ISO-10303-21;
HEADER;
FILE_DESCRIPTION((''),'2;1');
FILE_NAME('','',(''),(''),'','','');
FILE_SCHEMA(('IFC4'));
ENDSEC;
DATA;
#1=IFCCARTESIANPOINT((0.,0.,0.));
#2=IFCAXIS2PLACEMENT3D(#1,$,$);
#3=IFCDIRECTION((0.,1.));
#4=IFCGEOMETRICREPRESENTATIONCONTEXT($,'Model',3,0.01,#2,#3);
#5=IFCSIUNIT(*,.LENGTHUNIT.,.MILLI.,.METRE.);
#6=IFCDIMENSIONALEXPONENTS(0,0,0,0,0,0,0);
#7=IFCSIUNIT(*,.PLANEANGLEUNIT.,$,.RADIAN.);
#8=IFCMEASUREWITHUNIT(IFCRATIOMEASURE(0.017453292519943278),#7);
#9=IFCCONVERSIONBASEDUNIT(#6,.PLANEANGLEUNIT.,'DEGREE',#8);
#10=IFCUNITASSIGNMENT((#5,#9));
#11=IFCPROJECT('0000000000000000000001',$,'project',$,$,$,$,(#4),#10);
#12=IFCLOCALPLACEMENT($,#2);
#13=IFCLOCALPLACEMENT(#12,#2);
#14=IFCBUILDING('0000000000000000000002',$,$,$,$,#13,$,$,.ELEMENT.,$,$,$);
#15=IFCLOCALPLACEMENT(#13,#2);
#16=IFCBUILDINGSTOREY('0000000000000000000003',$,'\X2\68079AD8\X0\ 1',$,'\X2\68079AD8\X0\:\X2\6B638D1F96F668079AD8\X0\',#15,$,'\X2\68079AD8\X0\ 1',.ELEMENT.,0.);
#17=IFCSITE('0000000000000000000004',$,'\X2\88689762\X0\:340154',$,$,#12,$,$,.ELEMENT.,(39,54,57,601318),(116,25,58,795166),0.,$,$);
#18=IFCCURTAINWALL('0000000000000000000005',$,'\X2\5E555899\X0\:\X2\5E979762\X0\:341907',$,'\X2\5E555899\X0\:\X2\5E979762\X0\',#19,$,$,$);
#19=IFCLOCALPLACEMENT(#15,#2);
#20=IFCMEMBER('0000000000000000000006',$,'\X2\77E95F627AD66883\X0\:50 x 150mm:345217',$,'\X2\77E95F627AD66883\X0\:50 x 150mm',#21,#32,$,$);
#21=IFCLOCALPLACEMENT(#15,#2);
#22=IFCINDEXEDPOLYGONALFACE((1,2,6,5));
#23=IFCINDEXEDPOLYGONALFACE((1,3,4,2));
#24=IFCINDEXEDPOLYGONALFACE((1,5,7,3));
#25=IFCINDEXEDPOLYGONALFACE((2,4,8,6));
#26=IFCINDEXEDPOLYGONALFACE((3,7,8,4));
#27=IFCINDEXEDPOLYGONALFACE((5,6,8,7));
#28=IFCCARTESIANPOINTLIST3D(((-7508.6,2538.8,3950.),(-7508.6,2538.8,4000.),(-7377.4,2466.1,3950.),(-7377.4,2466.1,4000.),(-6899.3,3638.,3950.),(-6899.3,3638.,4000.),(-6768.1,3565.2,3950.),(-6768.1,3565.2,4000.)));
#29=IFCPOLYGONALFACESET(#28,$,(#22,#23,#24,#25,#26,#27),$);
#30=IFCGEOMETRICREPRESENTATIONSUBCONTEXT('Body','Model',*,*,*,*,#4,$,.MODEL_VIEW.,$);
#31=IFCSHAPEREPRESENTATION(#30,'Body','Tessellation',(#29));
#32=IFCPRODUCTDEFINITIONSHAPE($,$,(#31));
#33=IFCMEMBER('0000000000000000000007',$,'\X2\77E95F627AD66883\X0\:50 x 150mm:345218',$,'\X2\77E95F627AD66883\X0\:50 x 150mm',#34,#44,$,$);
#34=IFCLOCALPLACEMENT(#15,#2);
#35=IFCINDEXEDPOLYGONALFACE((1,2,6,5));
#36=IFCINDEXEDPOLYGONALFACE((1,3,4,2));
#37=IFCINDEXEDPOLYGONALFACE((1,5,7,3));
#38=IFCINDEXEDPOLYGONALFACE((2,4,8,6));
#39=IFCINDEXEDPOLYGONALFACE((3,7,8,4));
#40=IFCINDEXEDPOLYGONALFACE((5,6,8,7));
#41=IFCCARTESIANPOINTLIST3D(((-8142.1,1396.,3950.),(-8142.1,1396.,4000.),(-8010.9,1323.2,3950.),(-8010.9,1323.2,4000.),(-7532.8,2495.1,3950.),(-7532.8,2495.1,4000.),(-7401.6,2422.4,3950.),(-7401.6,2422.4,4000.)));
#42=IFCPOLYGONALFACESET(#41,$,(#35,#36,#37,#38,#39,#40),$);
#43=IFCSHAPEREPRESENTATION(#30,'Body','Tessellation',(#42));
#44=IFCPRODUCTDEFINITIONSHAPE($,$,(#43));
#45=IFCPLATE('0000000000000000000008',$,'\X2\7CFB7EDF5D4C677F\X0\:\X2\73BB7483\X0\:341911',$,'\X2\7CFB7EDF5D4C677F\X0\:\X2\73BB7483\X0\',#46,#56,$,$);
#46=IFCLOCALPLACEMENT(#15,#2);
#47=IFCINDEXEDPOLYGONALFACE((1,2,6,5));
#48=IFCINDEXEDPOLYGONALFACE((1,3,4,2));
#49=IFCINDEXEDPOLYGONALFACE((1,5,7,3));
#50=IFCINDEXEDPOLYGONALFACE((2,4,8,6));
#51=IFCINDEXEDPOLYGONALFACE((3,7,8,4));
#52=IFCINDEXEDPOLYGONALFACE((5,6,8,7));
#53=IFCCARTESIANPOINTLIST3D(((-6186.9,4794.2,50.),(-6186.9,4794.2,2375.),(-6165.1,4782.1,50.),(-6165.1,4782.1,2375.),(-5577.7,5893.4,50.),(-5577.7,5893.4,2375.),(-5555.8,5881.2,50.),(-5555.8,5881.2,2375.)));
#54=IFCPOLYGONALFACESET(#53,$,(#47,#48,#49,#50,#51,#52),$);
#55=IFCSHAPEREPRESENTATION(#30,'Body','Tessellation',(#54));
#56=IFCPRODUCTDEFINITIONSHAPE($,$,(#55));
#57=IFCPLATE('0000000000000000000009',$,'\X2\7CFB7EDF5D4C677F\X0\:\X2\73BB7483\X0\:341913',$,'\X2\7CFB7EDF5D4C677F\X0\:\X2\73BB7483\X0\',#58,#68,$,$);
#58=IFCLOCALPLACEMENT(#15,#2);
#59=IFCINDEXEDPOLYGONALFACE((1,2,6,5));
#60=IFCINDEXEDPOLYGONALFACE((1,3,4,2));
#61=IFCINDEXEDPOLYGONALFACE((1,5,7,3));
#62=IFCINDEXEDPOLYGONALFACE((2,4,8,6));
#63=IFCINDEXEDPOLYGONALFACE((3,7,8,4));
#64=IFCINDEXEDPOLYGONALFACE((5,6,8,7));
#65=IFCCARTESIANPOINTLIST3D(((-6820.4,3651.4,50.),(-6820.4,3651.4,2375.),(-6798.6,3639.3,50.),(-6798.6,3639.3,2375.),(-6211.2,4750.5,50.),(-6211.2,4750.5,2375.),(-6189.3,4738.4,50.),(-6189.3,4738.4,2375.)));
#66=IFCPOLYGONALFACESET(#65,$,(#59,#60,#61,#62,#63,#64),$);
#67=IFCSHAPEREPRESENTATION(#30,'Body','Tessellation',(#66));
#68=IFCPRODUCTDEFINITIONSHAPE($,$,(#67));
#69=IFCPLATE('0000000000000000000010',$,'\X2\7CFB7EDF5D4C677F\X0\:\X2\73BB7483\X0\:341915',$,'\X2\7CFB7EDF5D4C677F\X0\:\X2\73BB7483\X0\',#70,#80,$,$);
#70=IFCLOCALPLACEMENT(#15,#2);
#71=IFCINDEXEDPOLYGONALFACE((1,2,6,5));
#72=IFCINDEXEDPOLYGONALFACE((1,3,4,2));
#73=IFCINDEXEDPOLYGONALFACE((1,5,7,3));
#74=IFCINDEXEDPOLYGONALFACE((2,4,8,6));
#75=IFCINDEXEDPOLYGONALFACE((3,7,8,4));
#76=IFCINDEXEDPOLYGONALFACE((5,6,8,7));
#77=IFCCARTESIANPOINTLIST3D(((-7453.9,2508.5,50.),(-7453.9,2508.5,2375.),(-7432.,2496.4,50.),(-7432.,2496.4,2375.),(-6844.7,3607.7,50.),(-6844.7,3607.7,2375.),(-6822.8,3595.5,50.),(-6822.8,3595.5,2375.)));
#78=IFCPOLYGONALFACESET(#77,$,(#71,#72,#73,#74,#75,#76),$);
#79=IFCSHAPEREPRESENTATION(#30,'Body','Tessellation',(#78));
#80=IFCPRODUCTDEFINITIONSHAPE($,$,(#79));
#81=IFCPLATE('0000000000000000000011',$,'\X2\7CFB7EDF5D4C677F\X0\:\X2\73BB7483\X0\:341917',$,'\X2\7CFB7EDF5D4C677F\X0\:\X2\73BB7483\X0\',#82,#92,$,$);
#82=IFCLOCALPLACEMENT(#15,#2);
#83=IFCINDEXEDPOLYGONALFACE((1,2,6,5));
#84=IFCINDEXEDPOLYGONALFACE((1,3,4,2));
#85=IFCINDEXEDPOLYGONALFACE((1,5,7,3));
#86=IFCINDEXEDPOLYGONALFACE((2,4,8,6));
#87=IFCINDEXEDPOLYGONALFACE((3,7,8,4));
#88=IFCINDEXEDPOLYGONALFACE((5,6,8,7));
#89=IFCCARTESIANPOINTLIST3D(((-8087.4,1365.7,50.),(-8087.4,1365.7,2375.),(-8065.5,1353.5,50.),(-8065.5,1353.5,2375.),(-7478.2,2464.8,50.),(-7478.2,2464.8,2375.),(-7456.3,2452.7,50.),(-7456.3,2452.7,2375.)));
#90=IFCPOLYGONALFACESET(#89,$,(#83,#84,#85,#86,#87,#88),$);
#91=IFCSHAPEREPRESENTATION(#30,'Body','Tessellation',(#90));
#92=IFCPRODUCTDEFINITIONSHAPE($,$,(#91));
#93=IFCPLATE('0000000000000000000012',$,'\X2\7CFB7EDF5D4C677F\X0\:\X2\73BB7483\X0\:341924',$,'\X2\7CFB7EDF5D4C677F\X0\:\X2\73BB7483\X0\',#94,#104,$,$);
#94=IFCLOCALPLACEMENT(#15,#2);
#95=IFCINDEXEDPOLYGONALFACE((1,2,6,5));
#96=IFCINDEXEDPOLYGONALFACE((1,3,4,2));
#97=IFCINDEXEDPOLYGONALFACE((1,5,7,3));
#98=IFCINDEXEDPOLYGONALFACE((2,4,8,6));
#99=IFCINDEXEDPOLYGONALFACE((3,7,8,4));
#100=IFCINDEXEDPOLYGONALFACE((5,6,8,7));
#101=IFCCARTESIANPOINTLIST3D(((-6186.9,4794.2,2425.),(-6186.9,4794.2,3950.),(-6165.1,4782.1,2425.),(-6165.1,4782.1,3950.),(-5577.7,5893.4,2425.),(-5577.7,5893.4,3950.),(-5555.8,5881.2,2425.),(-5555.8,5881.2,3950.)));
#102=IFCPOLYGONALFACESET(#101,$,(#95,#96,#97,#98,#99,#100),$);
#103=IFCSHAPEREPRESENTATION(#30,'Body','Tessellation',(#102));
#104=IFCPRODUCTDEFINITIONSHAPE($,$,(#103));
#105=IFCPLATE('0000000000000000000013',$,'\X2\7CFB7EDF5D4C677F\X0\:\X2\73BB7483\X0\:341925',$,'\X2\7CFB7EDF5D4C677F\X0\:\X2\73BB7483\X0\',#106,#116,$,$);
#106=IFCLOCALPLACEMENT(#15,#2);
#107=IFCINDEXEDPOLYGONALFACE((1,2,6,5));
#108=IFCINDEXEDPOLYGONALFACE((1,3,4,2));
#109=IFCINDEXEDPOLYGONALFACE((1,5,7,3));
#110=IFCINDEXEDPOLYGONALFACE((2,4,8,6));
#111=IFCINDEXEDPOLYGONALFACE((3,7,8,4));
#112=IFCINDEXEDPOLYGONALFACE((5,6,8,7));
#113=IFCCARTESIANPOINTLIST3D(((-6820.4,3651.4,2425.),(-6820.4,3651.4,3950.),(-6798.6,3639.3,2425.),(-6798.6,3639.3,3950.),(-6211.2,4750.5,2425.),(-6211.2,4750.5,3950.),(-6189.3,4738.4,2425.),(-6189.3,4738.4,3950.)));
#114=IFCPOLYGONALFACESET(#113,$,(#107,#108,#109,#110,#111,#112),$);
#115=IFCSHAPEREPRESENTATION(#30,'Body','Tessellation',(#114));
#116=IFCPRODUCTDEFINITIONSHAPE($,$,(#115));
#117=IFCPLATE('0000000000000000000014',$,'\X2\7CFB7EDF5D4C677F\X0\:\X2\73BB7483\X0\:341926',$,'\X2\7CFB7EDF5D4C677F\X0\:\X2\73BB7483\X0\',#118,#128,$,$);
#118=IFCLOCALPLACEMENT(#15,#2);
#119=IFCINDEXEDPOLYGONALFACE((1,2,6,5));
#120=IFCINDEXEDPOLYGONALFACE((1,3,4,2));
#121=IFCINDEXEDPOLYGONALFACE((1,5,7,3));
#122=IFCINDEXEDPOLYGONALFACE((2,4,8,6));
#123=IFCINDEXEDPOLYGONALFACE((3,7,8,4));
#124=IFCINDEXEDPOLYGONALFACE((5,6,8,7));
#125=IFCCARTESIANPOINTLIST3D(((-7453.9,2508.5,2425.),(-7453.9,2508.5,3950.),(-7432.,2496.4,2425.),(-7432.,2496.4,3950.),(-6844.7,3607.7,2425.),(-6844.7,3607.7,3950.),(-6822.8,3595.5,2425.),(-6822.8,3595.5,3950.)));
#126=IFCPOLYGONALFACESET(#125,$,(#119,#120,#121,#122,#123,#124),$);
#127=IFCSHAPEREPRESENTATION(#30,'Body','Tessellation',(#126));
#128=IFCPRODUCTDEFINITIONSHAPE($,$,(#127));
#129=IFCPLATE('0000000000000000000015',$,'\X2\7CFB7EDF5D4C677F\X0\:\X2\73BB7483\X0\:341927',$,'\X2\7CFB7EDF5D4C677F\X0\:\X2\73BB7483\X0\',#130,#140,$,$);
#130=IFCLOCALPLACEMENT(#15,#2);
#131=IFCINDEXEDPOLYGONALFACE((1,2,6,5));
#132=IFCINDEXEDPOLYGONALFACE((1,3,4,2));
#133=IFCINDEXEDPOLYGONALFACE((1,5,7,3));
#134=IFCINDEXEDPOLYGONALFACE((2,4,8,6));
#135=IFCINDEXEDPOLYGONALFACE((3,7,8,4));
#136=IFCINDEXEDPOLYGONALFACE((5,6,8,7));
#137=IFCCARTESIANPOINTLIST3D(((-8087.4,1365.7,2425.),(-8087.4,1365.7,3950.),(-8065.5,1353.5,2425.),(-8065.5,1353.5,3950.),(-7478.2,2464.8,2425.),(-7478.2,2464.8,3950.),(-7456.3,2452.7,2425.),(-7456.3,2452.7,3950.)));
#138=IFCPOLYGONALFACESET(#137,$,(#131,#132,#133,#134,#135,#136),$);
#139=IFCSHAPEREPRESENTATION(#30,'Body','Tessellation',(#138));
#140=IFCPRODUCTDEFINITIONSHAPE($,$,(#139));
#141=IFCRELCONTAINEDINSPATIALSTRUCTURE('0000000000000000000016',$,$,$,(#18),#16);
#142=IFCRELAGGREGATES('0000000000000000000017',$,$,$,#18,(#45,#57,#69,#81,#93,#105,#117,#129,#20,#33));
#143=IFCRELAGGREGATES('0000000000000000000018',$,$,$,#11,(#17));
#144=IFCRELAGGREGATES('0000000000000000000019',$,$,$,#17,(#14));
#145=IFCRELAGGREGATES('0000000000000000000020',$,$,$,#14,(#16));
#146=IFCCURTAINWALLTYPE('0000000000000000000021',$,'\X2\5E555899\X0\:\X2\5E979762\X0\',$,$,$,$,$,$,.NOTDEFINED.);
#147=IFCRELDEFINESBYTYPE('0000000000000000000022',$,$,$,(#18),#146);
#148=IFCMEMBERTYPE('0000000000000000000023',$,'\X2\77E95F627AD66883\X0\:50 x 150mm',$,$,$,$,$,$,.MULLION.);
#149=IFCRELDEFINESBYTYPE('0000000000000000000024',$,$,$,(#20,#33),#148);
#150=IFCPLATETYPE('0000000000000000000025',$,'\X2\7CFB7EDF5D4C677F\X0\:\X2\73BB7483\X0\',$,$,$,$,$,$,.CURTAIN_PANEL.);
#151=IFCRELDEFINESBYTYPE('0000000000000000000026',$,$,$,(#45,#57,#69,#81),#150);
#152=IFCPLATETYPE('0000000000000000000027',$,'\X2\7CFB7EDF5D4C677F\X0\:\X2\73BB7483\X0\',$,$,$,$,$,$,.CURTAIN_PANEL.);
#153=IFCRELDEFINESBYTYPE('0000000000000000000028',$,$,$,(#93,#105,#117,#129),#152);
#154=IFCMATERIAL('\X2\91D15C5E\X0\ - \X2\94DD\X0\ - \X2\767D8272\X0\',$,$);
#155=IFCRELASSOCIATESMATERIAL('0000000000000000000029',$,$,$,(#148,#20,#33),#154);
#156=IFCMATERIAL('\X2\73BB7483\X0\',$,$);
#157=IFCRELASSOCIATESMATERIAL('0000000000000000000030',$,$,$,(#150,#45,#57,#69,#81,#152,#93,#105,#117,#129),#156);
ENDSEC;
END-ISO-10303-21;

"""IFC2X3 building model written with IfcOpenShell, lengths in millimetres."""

from ifc_helpers import new_model, entity, si_unit, converted_unit, direction, frame, frame_2d, origin, origin_2d_with_axis, place, context, subcontext, project, spatial, rectangle, extrude, source, transform, mapped, material, type_object, type_shapes, element, aggregate, save


model = new_model("IFC2X3")

# Units and contexts
model_context = context("Model", 3, precision=0.01, world=origin(), true_north=direction((0.0, 1.0)))
body_context = subcontext(model_context, "Body", "Model", "MODEL_VIEW")
ifc_project = project(units=[si_unit("LENGTHUNIT", "METRE", prefix="MILLI"), converted_unit("PLANEANGLEUNIT", "DEGREE", entity("IfcRatioMeasure", 0.017453292519943278), si_unit("PLANEANGLEUNIT", "RADIAN"), dimensions=[0, 0, 0, 0, 0, 0, 0])], contexts=[model_context])

# Site, building, storey
site_placement = place(None, origin())
site = spatial("IfcSite", under=ifc_project, at=site_placement, Name="表面:340154", CompositionType="ELEMENT", RefLatitude=(39, 54, 57, 601318), RefLongitude=(116, 25, 58, 795166), RefElevation=0.0)
building_placement = place(site_placement, origin())
building = spatial("IfcBuilding", under=site, at=building_placement, CompositionType="ELEMENT")
storey_placement = place(building_placement, origin())
storey = spatial("IfcBuildingStorey", under=building, at=storey_placement, Name="标高 1", ObjectType="标高:正负零标高", LongName="标高 1", CompositionType="ELEMENT", Elevation=0.0)

# Curtain wall, members, plates
curtain_wall_type = type_object("IfcCurtainWallType", Name="幕墙:店面", PredefinedType="NOTDEFINED")
curtain_wall_placement = place(storey_placement, origin())
curtain_wall = element("IfcCurtainWall", 1, at=curtain_wall_placement, inside=storey, type_object=curtain_wall_type, Name="幕墙:店面:341907", ObjectType="幕墙:店面")
ifc_material_1 = material(Name="金属 - 铝 - 白色")
member_type_1 = type_object("IfcMemberType", Name="矩形竖梃:50 x 150mm", PredefinedType="MULLION", material=ifc_material_1)
shared_shape_1 = source(origin(), body_context, "Body", "SweptSolid", [
    extrude(rectangle(XDim=150.0, YDim=50.0, at=origin_2d_with_axis()), frame((-25.0, 0.0, -1256.7), z_axis=(0.0, 0.0, 1.0), x_axis=(0.0, -1.0, 0.0)), (0.0, 0.0, 1.0), 1256.7),
])
type_shapes(member_type_1, [shared_shape_1])
member_1_placement = place(curtain_wall_placement, frame((-7443.0, 2502.5, 4000.0), z_axis=(-0.48481, -0.87462, 0.0), x_axis=(0.0, 0.0, 1.0)))
member_1 = element("IfcMember", 2, at=member_1_placement, type_object=member_type_1, material=ifc_material_1, Name="矩形竖梃:50 x 150mm:345217", ObjectType="矩形竖梃:50 x 150mm", context=body_context, shape_type="MappedRepresentation", body=[
    mapped(shared_shape_1, transform((0.0, 0.0, 0.0), scale=1.0)),
])
member_2_placement = place(curtain_wall_placement, frame((-8076.5, 1359.6, 4000.0), z_axis=(-0.48481, -0.87462, 0.0), x_axis=(0.0, 0.0, 1.0)))
member_2 = element("IfcMember", 3, at=member_2_placement, type_object=member_type_1, material=ifc_material_1, Name="矩形竖梃:50 x 150mm:345218", ObjectType="矩形竖梃:50 x 150mm", context=body_context, shape_type="MappedRepresentation", body=[
    mapped(shared_shape_1, transform((0.0, 0.0, 0.0), scale=1.0)),
])
ifc_material_2 = material(Name="玻璃")
plate_type_1 = type_object("IfcPlateType", Name="系统嵌板:玻璃", PredefinedType="CURTAIN_PANEL", material=ifc_material_2)
shared_shape_2 = source(origin(), body_context, "Body", "SweptSolid", [
    extrude(rectangle(XDim=25.0, YDim=1256.7, at=frame_2d((0.0, 0.0), x_axis=(1.0, 0.0))), frame((0.0, 0.0, 0.0), z_axis=(0.0, 0.0, 1.0), x_axis=(0.0, 1.0, 0.0)), (0.0, 0.0, 1.0), 2325.0),
])
type_shapes(plate_type_1, [shared_shape_2])
plate_1_placement = place(curtain_wall_placement, frame((-5871.4, 5337.7, 50.0), z_axis=(0.0, 0.0, 1.0), x_axis=(-0.48481, -0.87462, 0.0)))
plate_1 = element("IfcPlate", 4, at=plate_1_placement, type_object=plate_type_1, material=ifc_material_2, Name="系统嵌板:玻璃:341911", ObjectType="系统嵌板:玻璃", context=body_context, shape_type="MappedRepresentation", body=[
    mapped(shared_shape_2, transform((0.0, 0.0, 0.0), scale=1.0)),
])
plate_2_placement = place(curtain_wall_placement, frame((-6504.9, 4194.9, 50.0), z_axis=(0.0, 0.0, 1.0), x_axis=(-0.48481, -0.87462, 0.0)))
plate_2 = element("IfcPlate", 5, at=plate_2_placement, type_object=plate_type_1, material=ifc_material_2, Name="系统嵌板:玻璃:341913", ObjectType="系统嵌板:玻璃", context=body_context, shape_type="MappedRepresentation", body=[
    mapped(shared_shape_2, transform((0.0, 0.0, 0.0), scale=1.0)),
])
plate_3_placement = place(curtain_wall_placement, frame((-7138.4, 3052.0, 50.0), z_axis=(0.0, 0.0, 1.0), x_axis=(-0.48481, -0.87462, 0.0)))
plate_3 = element("IfcPlate", 6, at=plate_3_placement, type_object=plate_type_1, material=ifc_material_2, Name="系统嵌板:玻璃:341915", ObjectType="系统嵌板:玻璃", context=body_context, shape_type="MappedRepresentation", body=[
    mapped(shared_shape_2, transform((0.0, 0.0, 0.0), scale=1.0)),
])
plate_4_placement = place(curtain_wall_placement, frame((-7771.8, 1909.2, 50.0), z_axis=(0.0, 0.0, 1.0), x_axis=(-0.48481, -0.87462, 0.0)))
plate_4 = element("IfcPlate", 7, at=plate_4_placement, type_object=plate_type_1, material=ifc_material_2, Name="系统嵌板:玻璃:341917", ObjectType="系统嵌板:玻璃", context=body_context, shape_type="MappedRepresentation", body=[
    mapped(shared_shape_2, transform((0.0, 0.0, 0.0), scale=1.0)),
])
plate_type_2 = type_object("IfcPlateType", Name="系统嵌板:玻璃", PredefinedType="CURTAIN_PANEL", material=ifc_material_2)
shared_shape_3 = source(origin(), body_context, "Body", "SweptSolid", [
    extrude(rectangle(XDim=25.0, YDim=1256.7, at=frame_2d((0.0, 0.0), x_axis=(1.0, 0.0))), frame((0.0, 0.0, 0.0), z_axis=(0.0, 0.0, 1.0), x_axis=(0.0, 1.0, 0.0)), (0.0, 0.0, 1.0), 1525.0),
])
type_shapes(plate_type_2, [shared_shape_3])
plate_5_placement = place(curtain_wall_placement, frame((-5871.4, 5337.7, 2425.0), z_axis=(0.0, 0.0, 1.0), x_axis=(-0.48481, -0.87462, 0.0)))
plate_5 = element("IfcPlate", 8, at=plate_5_placement, type_object=plate_type_2, material=ifc_material_2, Name="系统嵌板:玻璃:341924", ObjectType="系统嵌板:玻璃", context=body_context, shape_type="MappedRepresentation", body=[
    mapped(shared_shape_3, transform((0.0, 0.0, 0.0), scale=1.0)),
])
plate_6_placement = place(curtain_wall_placement, frame((-6504.9, 4194.9, 2425.0), z_axis=(0.0, 0.0, 1.0), x_axis=(-0.48481, -0.87462, 0.0)))
plate_6 = element("IfcPlate", 9, at=plate_6_placement, type_object=plate_type_2, material=ifc_material_2, Name="系统嵌板:玻璃:341925", ObjectType="系统嵌板:玻璃", context=body_context, shape_type="MappedRepresentation", body=[
    mapped(shared_shape_3, transform((0.0, 0.0, 0.0), scale=1.0)),
])
plate_7_placement = place(curtain_wall_placement, frame((-7138.4, 3052.0, 2425.0), z_axis=(0.0, 0.0, 1.0), x_axis=(-0.48481, -0.87462, 0.0)))
plate_7 = element("IfcPlate", 10, at=plate_7_placement, type_object=plate_type_2, material=ifc_material_2, Name="系统嵌板:玻璃:341926", ObjectType="系统嵌板:玻璃", context=body_context, shape_type="MappedRepresentation", body=[
    mapped(shared_shape_3, transform((0.0, 0.0, 0.0), scale=1.0)),
])
plate_8_placement = place(curtain_wall_placement, frame((-7771.8, 1909.2, 2425.0), z_axis=(0.0, 0.0, 1.0), x_axis=(-0.48481, -0.87462, 0.0)))
plate_8 = element("IfcPlate", 11, at=plate_8_placement, type_object=plate_type_2, material=ifc_material_2, Name="系统嵌板:玻璃:341927", ObjectType="系统嵌板:玻璃", context=body_context, shape_type="MappedRepresentation", body=[
    mapped(shared_shape_3, transform((0.0, 0.0, 0.0), scale=1.0)),
])
aggregate(curtain_wall, [plate_1, plate_2, plate_3, plate_4, plate_5, plate_6, plate_7, plate_8, member_1, member_2])

save(model, "model.ifc")
